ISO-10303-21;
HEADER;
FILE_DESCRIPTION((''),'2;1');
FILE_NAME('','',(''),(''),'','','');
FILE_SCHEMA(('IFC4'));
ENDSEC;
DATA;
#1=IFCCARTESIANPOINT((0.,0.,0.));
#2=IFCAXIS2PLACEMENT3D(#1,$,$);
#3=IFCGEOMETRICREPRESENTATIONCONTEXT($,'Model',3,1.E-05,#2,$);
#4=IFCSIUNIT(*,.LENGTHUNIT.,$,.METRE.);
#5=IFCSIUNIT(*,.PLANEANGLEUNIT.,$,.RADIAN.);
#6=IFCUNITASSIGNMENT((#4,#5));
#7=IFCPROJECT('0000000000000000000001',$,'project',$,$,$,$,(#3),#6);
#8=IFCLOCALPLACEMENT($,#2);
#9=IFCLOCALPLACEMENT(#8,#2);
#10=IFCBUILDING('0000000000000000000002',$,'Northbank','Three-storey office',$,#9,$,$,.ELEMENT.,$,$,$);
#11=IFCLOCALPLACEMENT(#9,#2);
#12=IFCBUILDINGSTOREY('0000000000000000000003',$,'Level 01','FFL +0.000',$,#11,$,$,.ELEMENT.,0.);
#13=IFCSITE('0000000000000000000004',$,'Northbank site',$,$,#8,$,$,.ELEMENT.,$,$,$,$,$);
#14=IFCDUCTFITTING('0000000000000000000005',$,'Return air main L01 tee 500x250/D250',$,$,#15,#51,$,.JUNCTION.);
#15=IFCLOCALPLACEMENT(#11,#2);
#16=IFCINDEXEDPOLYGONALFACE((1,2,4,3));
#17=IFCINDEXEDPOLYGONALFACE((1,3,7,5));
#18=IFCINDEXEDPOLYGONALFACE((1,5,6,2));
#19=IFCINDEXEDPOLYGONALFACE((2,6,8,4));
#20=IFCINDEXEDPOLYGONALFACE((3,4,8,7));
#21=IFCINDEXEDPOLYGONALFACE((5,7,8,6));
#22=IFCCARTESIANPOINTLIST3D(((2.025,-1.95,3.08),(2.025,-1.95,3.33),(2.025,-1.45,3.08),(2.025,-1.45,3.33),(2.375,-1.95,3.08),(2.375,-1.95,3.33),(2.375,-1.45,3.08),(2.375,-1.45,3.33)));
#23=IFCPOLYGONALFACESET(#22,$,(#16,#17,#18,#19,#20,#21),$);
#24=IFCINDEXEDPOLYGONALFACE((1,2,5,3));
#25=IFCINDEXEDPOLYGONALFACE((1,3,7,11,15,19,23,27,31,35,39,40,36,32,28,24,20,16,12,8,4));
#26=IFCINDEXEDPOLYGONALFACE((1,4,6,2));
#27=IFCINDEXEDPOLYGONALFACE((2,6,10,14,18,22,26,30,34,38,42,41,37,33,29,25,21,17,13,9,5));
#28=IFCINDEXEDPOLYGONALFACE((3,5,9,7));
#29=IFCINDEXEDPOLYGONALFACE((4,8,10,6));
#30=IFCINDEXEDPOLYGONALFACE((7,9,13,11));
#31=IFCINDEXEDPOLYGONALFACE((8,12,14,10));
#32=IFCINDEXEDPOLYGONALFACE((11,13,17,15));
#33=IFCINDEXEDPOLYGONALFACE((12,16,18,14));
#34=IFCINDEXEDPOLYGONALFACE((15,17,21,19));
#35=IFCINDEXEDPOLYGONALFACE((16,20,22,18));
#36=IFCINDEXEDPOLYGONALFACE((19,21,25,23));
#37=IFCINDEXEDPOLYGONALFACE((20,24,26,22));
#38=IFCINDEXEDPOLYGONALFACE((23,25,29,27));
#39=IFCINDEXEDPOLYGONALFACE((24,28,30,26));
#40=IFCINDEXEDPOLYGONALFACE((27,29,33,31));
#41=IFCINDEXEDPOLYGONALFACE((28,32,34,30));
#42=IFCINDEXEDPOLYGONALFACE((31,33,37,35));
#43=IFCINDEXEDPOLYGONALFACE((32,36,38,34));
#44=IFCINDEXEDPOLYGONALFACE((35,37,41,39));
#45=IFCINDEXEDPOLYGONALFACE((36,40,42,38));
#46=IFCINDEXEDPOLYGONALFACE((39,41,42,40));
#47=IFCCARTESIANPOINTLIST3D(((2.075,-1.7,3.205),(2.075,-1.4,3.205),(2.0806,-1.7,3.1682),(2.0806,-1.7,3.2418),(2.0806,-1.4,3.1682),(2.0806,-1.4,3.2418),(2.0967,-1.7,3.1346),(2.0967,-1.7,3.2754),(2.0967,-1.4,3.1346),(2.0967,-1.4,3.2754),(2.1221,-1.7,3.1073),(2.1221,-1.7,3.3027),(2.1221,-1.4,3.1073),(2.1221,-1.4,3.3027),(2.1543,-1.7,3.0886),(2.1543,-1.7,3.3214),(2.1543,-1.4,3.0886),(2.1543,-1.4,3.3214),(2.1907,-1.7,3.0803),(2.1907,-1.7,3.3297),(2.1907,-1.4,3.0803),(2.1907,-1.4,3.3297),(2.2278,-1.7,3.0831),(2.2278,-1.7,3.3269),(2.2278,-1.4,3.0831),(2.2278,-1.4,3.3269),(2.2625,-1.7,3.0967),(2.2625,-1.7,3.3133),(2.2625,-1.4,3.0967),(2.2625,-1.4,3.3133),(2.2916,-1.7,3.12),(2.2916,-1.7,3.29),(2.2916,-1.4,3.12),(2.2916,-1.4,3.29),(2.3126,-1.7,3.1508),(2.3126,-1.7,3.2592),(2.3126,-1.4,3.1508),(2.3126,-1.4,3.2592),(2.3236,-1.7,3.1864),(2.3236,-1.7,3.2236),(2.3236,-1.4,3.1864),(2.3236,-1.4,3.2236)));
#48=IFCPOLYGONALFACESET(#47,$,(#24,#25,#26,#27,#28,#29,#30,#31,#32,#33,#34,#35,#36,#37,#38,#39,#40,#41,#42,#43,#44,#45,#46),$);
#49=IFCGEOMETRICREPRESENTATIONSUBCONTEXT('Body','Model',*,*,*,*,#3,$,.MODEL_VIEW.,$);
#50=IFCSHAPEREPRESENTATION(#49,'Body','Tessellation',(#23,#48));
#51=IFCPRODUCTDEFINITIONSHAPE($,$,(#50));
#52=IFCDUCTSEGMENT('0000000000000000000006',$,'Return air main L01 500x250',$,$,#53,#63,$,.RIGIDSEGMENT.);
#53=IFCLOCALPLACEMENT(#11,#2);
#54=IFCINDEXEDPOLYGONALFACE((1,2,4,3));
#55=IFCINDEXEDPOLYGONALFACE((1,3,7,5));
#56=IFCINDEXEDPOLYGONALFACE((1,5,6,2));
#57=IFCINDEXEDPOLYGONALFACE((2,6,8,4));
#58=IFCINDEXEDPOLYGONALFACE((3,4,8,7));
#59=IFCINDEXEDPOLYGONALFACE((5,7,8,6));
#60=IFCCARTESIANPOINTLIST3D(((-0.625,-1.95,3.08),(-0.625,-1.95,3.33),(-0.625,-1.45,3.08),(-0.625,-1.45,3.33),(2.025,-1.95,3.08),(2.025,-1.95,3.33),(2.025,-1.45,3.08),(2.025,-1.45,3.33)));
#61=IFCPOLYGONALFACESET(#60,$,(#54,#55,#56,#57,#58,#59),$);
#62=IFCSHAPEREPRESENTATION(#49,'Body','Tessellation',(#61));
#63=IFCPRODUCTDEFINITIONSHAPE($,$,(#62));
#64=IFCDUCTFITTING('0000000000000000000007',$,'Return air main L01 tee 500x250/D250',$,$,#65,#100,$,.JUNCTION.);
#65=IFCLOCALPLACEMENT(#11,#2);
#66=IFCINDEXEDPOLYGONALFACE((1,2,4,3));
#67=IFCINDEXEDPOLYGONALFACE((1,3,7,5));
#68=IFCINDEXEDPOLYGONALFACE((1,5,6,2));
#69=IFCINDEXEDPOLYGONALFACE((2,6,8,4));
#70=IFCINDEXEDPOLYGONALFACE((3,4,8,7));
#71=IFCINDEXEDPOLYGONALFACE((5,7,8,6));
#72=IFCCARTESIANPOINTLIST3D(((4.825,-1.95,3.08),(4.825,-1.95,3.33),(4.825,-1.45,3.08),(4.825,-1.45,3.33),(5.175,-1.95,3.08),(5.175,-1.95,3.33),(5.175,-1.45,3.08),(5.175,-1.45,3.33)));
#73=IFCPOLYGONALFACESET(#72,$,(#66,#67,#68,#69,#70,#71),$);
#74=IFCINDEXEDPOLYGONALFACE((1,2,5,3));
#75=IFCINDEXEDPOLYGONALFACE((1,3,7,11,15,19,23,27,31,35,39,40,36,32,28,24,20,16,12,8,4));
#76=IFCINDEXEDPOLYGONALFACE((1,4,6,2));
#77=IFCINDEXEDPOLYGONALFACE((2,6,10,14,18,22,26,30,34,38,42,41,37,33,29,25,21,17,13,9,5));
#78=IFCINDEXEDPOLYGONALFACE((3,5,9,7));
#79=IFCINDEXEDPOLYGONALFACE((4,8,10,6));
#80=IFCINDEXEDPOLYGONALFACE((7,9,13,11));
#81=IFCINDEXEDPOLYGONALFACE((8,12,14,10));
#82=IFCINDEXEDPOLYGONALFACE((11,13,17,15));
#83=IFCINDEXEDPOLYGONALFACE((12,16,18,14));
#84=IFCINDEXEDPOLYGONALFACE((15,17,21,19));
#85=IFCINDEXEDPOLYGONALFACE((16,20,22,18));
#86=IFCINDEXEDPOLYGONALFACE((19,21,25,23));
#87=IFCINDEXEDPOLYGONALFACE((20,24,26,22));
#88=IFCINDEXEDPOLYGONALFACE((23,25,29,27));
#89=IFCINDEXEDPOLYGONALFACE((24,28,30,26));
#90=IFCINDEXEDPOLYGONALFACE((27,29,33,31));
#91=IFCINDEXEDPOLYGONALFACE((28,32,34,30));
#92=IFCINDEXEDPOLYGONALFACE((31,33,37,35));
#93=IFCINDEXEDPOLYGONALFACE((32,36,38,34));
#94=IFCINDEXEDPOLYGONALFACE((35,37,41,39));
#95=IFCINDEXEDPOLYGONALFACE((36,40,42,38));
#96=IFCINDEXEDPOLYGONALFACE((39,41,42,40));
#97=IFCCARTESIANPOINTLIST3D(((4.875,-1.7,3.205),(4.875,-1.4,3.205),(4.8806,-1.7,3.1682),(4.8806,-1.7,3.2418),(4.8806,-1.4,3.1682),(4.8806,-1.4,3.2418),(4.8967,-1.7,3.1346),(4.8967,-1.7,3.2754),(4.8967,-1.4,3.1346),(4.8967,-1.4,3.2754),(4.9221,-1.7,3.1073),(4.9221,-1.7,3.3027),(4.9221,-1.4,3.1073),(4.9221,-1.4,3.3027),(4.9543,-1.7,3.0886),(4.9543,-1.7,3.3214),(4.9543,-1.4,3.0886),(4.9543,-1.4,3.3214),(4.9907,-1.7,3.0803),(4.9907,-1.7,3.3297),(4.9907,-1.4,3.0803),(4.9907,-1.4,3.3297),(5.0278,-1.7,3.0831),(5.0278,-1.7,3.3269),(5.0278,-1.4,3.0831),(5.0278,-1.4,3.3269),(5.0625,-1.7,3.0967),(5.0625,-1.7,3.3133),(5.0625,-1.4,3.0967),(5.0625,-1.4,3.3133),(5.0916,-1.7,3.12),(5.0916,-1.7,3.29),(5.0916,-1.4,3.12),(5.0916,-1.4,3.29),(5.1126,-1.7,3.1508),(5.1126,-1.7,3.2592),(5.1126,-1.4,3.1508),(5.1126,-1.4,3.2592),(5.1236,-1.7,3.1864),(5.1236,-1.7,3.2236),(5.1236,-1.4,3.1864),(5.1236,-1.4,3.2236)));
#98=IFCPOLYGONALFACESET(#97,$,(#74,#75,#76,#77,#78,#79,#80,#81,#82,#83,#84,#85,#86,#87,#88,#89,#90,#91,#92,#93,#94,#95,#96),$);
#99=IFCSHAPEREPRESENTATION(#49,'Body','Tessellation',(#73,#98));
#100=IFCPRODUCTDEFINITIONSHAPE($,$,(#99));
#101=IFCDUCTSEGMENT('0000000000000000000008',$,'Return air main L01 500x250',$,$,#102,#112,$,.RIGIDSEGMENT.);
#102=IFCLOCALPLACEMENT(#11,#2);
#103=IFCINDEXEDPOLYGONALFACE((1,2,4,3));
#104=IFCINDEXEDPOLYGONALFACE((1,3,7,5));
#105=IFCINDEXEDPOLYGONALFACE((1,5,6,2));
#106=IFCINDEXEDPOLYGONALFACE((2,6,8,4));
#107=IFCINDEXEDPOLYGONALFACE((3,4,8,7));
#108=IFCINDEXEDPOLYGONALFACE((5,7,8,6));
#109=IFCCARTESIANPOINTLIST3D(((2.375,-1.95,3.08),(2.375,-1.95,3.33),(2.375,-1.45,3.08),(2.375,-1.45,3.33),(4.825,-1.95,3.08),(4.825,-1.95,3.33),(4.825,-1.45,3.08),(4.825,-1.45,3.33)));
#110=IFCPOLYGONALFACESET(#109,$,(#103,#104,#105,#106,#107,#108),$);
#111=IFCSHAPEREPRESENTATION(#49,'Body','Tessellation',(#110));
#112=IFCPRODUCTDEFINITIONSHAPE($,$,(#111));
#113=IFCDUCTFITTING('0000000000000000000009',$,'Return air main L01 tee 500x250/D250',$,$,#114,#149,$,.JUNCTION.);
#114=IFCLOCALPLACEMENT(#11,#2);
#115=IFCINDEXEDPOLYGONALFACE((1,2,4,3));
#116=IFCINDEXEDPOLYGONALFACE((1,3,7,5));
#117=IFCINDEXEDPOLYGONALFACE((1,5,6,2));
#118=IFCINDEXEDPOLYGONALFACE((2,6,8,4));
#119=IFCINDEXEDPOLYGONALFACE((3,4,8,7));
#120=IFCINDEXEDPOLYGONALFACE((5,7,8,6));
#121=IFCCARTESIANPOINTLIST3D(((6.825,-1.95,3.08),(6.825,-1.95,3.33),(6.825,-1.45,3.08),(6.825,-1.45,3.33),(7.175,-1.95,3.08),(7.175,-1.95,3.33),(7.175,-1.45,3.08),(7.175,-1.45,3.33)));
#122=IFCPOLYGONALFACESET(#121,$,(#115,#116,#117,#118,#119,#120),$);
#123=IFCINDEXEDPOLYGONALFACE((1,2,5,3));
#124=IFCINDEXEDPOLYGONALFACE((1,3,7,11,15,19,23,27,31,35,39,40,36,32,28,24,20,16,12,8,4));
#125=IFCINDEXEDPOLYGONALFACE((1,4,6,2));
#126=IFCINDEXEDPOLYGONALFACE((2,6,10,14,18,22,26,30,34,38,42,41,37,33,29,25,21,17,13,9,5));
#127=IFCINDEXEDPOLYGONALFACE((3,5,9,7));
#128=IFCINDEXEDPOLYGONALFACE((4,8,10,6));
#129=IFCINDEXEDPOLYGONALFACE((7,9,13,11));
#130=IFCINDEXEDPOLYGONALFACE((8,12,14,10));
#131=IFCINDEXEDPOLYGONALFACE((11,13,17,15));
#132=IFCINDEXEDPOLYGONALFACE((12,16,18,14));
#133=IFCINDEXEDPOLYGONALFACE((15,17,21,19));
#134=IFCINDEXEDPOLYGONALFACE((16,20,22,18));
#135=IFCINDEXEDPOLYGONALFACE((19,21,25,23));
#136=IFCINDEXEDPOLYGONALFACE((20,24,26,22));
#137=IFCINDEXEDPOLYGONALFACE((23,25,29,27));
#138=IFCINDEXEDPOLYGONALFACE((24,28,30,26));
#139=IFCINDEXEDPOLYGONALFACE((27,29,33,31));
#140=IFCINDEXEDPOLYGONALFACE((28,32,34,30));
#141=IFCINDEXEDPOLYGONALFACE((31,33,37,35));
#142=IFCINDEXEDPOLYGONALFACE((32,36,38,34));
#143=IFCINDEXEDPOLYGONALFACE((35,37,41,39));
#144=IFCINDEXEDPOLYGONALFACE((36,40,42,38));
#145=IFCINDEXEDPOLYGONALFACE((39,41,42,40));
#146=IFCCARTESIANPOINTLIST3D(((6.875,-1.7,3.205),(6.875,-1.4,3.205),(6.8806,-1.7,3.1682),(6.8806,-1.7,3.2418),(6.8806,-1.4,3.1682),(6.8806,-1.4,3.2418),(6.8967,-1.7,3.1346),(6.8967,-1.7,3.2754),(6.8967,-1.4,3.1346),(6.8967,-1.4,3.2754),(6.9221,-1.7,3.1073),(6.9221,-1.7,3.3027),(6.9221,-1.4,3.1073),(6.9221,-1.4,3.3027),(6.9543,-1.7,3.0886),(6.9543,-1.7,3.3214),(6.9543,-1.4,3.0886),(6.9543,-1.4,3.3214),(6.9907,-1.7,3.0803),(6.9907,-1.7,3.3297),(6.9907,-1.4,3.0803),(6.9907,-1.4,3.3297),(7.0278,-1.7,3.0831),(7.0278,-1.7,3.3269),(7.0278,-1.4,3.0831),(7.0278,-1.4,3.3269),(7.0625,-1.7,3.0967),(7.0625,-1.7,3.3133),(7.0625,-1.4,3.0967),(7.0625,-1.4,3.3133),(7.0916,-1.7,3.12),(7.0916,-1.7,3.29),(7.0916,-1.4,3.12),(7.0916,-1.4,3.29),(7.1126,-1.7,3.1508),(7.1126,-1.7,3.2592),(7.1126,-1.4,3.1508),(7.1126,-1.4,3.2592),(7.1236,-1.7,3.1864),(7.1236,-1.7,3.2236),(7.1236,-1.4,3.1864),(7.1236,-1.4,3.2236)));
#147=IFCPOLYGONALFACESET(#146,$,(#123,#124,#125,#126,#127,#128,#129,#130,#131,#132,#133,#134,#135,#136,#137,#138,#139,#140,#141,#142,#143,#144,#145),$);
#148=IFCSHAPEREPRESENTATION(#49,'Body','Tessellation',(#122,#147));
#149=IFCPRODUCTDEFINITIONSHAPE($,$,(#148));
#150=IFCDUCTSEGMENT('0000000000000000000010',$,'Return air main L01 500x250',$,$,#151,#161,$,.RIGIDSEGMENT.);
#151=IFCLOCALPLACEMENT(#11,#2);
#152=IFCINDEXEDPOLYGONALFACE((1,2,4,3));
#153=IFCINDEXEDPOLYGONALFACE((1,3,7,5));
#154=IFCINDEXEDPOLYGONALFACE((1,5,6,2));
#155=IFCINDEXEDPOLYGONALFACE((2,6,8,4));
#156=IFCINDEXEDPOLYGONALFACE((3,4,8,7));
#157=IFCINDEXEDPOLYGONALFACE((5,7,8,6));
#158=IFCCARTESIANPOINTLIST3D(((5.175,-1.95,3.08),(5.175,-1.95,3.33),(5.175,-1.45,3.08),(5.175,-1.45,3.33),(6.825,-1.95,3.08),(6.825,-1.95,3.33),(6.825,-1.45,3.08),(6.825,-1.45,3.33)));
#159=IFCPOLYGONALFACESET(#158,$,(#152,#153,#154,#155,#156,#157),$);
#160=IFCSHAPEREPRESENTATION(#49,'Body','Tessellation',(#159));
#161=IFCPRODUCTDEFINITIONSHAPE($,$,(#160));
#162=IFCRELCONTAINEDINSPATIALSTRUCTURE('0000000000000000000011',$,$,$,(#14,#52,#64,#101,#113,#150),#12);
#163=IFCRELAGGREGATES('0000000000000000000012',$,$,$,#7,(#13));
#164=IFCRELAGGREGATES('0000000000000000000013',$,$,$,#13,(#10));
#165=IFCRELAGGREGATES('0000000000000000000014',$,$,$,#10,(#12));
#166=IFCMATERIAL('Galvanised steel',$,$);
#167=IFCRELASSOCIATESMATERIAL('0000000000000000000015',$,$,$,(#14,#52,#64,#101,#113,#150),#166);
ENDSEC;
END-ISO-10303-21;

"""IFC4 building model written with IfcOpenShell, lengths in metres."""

from ifc_helpers import new_model, si_unit, frame, origin, place, context, subcontext, project, spatial, rectangle, circle, extrude, material, element, save


model = new_model("IFC4")

# Units and contexts
model_context = context("Model", 3, precision=1e-05, world=origin())
body_context = subcontext(model_context, "Body", "Model", "MODEL_VIEW")
ifc_project = project(units=[si_unit("LENGTHUNIT", "METRE"), si_unit("PLANEANGLEUNIT", "RADIAN")], contexts=[model_context])

# Site, building, storey
site_placement = place(None, origin())
site = spatial("IfcSite", under=ifc_project, at=site_placement, Name="Northbank site", CompositionType="ELEMENT")
building_placement = place(site_placement, origin())
building = spatial("IfcBuilding", under=site, at=building_placement, Name="Northbank", Description="Three-storey office", CompositionType="ELEMENT")
storey_placement = place(building_placement, origin())
storey = spatial("IfcBuildingStorey", under=building, at=storey_placement, Name="Level 01", Description="FFL +0.000", CompositionType="ELEMENT", Elevation=0.0)

# Shared definitions
ifc_material_1 = material(Name="Galvanised steel")

# Duct fitting
duct_fitting_1_placement = place(storey_placement, origin())
element("IfcDuctFitting", 1, at=duct_fitting_1_placement, inside=storey, material=ifc_material_1, Name="Return air main L01 tee 500x250/D250", PredefinedType="JUNCTION", context=body_context, shape_type="SweptSolid", body=[
    extrude(rectangle(XDim=0.5, YDim=0.25), frame((2.025, -1.7, 3.205), z_axis=(1.0, 0.0, 0.0), x_axis=(0.0, 1.0, 0.0)), (0.0, 0.0, 1.0), 0.35),
    extrude(circle(Radius=0.125), frame((2.2, -1.7, 3.205), z_axis=(0.0, 1.0, 0.0), x_axis=(-1.0, 0.0, 0.0)), (0.0, 0.0, 1.0), 0.3),
])

# Duct segment
duct_segment_1_placement = place(storey_placement, origin())
element("IfcDuctSegment", 2, at=duct_segment_1_placement, inside=storey, material=ifc_material_1, Name="Return air main L01 500x250", PredefinedType="RIGIDSEGMENT", context=body_context, shape_type="SweptSolid", body=[
    extrude(rectangle(XDim=0.5, YDim=0.25), frame((-0.625, -1.7, 3.205), z_axis=(1.0, 0.0, 0.0), x_axis=(0.0, 1.0, 0.0)), (0.0, 0.0, 1.0), 2.65),
])

# Duct fitting
duct_fitting_2_placement = place(storey_placement, origin())
element("IfcDuctFitting", 3, at=duct_fitting_2_placement, inside=storey, material=ifc_material_1, Name="Return air main L01 tee 500x250/D250", PredefinedType="JUNCTION", context=body_context, shape_type="SweptSolid", body=[
    extrude(rectangle(XDim=0.5, YDim=0.25), frame((4.825, -1.7, 3.205), z_axis=(1.0, 0.0, 0.0), x_axis=(0.0, 1.0, 0.0)), (0.0, 0.0, 1.0), 0.35),
    extrude(circle(Radius=0.125), frame((5.0, -1.7, 3.205), z_axis=(0.0, 1.0, 0.0), x_axis=(-1.0, 0.0, 0.0)), (0.0, 0.0, 1.0), 0.3),
])

# Duct segment
duct_segment_2_placement = place(storey_placement, origin())
element("IfcDuctSegment", 4, at=duct_segment_2_placement, inside=storey, material=ifc_material_1, Name="Return air main L01 500x250", PredefinedType="RIGIDSEGMENT", context=body_context, shape_type="SweptSolid", body=[
    extrude(rectangle(XDim=0.5, YDim=0.25), frame((2.375, -1.7, 3.205), z_axis=(1.0, 0.0, 0.0), x_axis=(0.0, 1.0, 0.0)), (0.0, 0.0, 1.0), 2.45),
])

# Duct fitting
duct_fitting_3_placement = place(storey_placement, origin())
element("IfcDuctFitting", 5, at=duct_fitting_3_placement, inside=storey, material=ifc_material_1, Name="Return air main L01 tee 500x250/D250", PredefinedType="JUNCTION", context=body_context, shape_type="SweptSolid", body=[
    extrude(rectangle(XDim=0.5, YDim=0.25), frame((6.825, -1.7, 3.205), z_axis=(1.0, 0.0, 0.0), x_axis=(0.0, 1.0, 0.0)), (0.0, 0.0, 1.0), 0.35),
    extrude(circle(Radius=0.125), frame((7.0, -1.7, 3.205), z_axis=(0.0, 1.0, 0.0), x_axis=(-1.0, 0.0, 0.0)), (0.0, 0.0, 1.0), 0.3),
])

# Duct segment
duct_segment_3_placement = place(storey_placement, origin())
element("IfcDuctSegment", 6, at=duct_segment_3_placement, inside=storey, material=ifc_material_1, Name="Return air main L01 500x250", PredefinedType="RIGIDSEGMENT", context=body_context, shape_type="SweptSolid", body=[
    extrude(rectangle(XDim=0.5, YDim=0.25), frame((5.175, -1.7, 3.205), z_axis=(1.0, 0.0, 0.0), x_axis=(0.0, 1.0, 0.0)), (0.0, 0.0, 1.0), 1.65),
])

save(model, "model.ifc")
